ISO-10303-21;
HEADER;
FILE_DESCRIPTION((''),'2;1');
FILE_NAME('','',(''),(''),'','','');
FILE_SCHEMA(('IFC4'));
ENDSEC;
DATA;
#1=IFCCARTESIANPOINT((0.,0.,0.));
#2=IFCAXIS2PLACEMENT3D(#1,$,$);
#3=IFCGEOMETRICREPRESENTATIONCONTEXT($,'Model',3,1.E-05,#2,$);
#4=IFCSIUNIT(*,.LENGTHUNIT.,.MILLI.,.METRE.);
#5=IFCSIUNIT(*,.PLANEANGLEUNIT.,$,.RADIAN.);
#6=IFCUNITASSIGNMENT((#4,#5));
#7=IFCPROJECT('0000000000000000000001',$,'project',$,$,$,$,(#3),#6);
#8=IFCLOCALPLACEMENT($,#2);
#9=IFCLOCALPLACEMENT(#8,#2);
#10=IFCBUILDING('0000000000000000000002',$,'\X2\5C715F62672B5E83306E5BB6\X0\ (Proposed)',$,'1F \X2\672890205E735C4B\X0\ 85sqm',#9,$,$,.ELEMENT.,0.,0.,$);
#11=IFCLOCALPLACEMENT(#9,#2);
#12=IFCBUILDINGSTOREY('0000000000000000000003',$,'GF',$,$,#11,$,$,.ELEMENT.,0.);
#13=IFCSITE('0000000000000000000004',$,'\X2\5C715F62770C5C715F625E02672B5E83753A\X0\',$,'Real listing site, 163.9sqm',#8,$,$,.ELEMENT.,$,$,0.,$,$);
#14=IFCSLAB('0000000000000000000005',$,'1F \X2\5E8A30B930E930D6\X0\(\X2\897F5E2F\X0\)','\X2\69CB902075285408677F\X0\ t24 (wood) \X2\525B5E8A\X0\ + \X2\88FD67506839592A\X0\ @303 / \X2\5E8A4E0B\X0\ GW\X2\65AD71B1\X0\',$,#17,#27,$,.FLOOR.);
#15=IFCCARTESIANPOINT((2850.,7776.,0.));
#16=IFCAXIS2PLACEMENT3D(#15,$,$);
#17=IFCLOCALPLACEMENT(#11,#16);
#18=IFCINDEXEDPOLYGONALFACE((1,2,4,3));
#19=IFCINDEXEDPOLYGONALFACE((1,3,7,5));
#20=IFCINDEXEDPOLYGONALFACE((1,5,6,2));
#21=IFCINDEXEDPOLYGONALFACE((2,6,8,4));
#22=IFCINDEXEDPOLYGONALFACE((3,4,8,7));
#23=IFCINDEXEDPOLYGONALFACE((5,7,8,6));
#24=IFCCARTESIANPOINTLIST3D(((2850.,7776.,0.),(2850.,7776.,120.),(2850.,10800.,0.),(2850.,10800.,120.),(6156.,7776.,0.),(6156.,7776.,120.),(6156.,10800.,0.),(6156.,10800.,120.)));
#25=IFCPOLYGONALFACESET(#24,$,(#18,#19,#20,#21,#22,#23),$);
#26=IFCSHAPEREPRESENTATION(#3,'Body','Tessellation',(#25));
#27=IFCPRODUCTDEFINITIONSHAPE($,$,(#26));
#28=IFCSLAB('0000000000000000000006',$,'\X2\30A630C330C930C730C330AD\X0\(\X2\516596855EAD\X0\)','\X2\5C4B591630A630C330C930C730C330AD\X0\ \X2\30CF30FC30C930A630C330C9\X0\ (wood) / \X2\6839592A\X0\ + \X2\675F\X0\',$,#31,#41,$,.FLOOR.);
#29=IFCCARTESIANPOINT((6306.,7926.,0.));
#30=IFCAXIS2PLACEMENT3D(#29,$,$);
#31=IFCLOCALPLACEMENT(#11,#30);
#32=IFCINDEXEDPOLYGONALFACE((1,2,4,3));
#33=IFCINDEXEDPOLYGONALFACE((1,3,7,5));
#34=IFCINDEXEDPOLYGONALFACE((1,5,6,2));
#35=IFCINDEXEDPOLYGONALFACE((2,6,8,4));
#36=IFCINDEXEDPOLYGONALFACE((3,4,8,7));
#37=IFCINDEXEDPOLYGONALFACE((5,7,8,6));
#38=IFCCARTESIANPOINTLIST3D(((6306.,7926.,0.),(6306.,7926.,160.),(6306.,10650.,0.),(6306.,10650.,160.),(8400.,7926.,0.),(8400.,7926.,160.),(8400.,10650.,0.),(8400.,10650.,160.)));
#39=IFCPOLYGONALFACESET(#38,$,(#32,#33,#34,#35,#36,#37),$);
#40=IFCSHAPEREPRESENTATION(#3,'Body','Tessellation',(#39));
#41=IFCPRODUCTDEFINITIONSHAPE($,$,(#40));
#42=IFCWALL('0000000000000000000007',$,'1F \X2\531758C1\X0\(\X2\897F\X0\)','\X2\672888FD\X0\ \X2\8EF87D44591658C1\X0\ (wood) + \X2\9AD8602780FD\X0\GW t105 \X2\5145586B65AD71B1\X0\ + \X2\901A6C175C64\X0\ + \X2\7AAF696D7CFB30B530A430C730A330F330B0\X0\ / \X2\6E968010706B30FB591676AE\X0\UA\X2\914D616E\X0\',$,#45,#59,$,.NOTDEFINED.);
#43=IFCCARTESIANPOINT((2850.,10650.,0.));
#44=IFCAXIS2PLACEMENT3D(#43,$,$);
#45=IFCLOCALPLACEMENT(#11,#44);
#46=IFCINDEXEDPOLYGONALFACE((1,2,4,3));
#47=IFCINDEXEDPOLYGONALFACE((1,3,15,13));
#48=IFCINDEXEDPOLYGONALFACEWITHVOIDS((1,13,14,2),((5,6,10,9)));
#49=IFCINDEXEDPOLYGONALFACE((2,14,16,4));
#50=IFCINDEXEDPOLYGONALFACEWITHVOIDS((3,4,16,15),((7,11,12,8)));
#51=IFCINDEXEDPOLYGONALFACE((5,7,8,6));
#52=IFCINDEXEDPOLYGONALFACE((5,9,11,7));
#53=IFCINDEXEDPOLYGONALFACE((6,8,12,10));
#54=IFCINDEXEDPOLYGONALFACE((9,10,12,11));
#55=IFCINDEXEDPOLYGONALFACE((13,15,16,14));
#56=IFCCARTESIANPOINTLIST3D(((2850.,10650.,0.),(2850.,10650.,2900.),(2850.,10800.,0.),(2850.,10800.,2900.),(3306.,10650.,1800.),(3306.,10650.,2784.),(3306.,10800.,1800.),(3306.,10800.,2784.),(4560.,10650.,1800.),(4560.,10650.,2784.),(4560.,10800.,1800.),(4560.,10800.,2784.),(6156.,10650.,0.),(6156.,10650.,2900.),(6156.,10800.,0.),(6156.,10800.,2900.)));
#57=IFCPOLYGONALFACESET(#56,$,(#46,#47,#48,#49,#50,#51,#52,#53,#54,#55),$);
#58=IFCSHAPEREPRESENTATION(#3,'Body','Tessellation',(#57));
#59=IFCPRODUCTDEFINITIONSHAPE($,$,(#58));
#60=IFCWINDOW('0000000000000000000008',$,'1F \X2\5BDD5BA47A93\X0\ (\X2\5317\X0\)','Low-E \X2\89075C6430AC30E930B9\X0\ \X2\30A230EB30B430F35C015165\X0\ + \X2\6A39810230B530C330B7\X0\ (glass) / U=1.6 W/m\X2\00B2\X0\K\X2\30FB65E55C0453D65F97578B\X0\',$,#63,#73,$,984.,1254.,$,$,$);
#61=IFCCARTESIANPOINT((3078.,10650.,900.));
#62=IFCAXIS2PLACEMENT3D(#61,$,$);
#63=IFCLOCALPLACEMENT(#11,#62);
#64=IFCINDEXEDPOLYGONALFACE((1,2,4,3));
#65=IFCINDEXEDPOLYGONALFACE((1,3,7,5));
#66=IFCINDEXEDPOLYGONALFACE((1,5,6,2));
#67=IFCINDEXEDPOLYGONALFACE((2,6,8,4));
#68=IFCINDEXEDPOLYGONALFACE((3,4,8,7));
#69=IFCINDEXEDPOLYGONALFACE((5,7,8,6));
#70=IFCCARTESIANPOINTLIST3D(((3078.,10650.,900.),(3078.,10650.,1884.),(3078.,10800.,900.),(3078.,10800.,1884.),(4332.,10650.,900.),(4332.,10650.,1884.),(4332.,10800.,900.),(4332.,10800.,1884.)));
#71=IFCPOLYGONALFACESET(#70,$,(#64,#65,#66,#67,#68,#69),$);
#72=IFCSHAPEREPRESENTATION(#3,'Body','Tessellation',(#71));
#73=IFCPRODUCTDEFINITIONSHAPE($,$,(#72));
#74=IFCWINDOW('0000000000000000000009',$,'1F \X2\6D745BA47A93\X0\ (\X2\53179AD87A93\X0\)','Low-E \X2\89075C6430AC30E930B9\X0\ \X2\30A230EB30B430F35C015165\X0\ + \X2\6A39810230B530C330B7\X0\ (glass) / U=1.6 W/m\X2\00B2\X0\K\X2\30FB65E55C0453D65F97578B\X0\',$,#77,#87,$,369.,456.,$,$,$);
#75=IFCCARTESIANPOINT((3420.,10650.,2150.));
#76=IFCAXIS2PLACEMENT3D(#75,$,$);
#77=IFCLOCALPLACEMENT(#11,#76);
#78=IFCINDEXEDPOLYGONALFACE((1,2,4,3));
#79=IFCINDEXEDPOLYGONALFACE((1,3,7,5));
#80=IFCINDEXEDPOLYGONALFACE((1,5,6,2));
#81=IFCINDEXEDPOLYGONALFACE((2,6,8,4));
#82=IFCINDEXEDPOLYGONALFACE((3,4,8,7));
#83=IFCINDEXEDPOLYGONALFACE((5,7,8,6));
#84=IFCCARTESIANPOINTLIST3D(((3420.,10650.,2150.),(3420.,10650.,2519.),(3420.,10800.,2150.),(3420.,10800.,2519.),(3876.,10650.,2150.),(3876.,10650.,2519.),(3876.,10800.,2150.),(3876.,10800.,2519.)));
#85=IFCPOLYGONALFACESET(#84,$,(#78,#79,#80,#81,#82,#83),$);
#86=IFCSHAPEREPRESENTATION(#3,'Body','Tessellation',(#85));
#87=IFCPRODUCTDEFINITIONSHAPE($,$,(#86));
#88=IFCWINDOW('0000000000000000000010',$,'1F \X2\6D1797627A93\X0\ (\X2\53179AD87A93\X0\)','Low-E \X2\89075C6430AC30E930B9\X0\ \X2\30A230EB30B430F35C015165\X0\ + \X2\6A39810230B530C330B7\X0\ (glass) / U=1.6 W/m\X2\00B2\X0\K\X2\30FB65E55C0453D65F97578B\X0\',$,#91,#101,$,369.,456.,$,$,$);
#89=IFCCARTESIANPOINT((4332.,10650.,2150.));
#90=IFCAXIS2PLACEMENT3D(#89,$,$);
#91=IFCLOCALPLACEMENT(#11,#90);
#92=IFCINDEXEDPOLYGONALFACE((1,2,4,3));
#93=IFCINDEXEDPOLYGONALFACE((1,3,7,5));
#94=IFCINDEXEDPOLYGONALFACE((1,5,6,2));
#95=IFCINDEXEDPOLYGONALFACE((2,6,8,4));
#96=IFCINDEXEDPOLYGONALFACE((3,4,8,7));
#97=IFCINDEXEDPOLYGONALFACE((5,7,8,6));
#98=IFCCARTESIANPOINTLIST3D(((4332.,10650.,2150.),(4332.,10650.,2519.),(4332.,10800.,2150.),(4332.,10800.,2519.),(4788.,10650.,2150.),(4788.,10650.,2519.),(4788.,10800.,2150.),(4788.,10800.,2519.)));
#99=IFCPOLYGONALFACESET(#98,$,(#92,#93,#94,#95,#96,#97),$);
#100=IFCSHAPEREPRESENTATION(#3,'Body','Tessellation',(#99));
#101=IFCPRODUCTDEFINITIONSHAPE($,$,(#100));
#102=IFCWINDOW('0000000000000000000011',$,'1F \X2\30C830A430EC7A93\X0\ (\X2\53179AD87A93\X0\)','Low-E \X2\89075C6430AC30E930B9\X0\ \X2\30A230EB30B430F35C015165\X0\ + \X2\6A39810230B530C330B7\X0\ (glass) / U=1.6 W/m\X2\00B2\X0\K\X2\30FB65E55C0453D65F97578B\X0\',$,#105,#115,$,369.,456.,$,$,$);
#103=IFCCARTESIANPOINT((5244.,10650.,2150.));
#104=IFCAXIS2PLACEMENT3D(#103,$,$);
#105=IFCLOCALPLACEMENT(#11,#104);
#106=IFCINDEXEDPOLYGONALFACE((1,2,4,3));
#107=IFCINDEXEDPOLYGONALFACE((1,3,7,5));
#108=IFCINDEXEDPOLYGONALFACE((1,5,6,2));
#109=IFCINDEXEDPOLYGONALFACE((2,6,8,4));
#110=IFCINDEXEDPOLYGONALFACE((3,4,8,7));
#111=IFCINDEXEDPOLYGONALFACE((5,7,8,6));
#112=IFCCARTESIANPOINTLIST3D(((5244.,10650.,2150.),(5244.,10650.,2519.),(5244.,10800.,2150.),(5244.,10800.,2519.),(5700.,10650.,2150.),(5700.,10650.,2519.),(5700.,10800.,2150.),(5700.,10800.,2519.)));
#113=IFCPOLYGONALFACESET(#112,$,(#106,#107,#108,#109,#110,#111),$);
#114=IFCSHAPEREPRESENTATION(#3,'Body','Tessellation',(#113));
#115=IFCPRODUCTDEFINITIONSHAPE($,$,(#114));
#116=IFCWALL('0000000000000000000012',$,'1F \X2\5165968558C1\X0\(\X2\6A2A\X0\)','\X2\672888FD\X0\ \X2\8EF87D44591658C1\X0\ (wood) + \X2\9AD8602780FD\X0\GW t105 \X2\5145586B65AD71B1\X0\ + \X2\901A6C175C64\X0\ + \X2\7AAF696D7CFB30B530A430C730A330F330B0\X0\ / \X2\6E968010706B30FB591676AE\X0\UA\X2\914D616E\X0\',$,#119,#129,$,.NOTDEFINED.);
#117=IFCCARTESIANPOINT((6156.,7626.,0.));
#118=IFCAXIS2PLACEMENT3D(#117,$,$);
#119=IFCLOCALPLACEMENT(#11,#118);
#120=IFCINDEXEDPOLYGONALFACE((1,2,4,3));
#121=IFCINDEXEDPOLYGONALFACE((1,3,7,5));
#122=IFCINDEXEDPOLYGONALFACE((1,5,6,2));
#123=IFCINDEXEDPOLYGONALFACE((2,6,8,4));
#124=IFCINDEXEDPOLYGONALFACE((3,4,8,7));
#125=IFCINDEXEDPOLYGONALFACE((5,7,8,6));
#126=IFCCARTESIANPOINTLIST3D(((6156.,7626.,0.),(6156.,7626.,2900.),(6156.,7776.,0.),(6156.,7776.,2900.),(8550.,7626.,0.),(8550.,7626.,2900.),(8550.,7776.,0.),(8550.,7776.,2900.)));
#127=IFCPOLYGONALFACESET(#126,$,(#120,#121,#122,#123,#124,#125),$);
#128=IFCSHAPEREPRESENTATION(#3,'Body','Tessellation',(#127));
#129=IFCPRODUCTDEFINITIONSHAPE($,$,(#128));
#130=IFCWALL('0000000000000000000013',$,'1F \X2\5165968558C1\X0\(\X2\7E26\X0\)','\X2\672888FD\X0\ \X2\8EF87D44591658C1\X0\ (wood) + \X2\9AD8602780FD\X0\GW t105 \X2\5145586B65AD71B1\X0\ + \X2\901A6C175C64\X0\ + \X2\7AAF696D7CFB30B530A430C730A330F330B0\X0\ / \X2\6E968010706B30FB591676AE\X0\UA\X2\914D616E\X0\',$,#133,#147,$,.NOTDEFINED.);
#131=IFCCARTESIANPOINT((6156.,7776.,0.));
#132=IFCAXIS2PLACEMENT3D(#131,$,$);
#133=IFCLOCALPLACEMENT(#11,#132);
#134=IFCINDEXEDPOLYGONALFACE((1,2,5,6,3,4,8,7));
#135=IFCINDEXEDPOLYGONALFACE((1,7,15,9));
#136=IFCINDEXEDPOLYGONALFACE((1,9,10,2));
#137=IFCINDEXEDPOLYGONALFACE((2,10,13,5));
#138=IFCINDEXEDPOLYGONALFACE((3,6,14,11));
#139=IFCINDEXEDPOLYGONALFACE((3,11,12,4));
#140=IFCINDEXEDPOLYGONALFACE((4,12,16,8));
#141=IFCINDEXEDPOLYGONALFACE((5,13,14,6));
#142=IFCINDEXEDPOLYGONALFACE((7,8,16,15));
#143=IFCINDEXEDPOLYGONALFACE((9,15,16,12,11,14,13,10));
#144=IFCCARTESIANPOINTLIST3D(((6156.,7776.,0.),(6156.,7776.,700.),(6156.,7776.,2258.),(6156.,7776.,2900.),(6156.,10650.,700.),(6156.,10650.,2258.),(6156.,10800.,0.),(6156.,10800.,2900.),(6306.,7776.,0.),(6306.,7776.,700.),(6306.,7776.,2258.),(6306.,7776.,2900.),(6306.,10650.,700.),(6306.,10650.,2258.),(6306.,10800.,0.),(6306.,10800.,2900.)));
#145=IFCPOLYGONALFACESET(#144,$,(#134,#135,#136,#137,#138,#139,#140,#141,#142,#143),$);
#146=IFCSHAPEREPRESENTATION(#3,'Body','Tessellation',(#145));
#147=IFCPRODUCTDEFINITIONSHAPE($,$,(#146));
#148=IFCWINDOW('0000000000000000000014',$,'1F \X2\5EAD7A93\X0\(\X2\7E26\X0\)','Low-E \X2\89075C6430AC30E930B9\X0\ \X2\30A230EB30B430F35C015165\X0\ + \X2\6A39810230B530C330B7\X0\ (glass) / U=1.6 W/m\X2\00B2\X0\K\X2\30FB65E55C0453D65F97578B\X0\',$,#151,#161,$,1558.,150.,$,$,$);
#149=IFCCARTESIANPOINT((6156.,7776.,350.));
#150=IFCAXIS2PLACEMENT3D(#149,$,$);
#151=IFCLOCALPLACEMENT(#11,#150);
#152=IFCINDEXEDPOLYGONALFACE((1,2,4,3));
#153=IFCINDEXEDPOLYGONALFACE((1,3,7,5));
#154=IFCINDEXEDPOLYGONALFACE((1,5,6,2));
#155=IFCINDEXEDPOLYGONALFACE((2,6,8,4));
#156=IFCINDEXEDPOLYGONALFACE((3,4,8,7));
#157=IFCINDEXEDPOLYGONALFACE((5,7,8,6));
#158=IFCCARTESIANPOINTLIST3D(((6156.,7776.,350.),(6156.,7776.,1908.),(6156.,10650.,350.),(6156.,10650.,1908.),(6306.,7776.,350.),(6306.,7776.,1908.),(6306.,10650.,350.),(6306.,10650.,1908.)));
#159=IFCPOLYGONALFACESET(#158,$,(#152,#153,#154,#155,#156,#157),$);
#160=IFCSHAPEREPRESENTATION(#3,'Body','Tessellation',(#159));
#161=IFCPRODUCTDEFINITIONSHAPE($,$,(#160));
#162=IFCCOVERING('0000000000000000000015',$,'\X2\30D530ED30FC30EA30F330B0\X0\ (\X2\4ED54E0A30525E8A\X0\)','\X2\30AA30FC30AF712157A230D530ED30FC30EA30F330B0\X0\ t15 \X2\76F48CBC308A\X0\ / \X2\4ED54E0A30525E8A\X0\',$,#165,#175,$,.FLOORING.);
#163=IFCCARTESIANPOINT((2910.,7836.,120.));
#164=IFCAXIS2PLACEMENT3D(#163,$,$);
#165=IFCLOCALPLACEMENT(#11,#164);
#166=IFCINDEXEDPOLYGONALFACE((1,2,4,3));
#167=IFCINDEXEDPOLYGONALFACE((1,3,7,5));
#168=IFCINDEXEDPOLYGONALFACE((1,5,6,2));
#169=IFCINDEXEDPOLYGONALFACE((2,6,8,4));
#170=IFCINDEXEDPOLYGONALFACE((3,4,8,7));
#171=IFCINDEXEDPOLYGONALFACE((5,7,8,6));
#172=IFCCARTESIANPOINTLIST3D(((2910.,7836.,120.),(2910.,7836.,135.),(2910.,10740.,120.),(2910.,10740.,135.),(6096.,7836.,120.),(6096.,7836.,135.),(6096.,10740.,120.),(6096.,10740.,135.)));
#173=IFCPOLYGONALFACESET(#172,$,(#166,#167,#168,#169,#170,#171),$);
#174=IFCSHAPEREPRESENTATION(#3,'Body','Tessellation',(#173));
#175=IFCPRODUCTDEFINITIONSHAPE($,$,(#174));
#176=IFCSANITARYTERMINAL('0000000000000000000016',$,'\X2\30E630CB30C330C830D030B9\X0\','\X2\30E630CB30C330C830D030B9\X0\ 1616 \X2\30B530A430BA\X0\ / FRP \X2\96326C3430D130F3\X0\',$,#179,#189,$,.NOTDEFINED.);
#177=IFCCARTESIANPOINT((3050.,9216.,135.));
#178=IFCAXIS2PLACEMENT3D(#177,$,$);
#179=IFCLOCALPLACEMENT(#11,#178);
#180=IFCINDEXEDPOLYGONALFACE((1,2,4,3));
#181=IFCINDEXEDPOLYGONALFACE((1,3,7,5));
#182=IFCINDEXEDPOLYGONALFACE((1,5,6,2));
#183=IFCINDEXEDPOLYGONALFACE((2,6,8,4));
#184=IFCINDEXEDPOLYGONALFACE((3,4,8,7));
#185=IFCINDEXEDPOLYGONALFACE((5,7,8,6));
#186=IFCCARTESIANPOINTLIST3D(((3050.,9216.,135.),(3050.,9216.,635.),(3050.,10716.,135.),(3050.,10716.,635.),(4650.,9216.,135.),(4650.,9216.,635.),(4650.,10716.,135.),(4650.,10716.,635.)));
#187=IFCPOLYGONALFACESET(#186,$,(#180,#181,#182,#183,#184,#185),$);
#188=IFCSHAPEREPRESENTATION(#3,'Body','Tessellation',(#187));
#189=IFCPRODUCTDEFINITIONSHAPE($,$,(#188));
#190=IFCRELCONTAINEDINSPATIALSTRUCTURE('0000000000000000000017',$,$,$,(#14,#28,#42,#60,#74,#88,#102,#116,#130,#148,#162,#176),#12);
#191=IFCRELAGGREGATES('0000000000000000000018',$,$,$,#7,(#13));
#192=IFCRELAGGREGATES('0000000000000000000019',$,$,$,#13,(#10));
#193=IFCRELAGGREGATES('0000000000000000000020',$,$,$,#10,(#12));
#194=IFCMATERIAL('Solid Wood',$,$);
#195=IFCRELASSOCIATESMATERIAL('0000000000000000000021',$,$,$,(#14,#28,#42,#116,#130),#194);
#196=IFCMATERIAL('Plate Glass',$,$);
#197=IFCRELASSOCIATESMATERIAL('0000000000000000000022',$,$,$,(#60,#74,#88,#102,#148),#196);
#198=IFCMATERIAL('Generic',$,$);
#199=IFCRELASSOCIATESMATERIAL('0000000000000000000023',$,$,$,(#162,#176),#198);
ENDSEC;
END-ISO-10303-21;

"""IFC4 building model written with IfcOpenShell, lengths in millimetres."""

from ifc_helpers import new_model, si_unit, frame, frame_2d, origin, place, context, project, spatial, rectangle, extrude, material, element, fill, save


model = new_model("IFC4")

# Units and contexts
model_context = context("Model", 3, precision=1e-05, world=origin())
ifc_project = project(units=[si_unit("LENGTHUNIT", "METRE", prefix="MILLI"), si_unit("PLANEANGLEUNIT", "RADIAN")], contexts=[model_context])

# Site, building, storey
site_placement = place(None, origin())
site = spatial("IfcSite", under=ifc_project, at=site_placement, Name="山形県山形市末広町", ObjectType="Real listing site, 163.9sqm", CompositionType="ELEMENT", RefElevation=0.0)
building_placement = place(site_placement, origin())
building = spatial("IfcBuilding", under=site, at=building_placement, Name="山形末広の家 (Proposed)", ObjectType="1F 木造平屋 85sqm", CompositionType="ELEMENT", ElevationOfRefHeight=0.0, ElevationOfTerrain=0.0)
storey_placement = place(building_placement, origin())
storey = spatial("IfcBuildingStorey", under=building, at=storey_placement, Name="GF", CompositionType="ELEMENT", Elevation=0.0)

# Slabs
ifc_material_1 = material(Name="Solid Wood")
slab_1_placement = place(storey_placement, frame((2850.0, 7776.0, 0.0)))
element("IfcSlab", 1, at=slab_1_placement, inside=storey, material=ifc_material_1, Name="1F 床スラブ(西帯)", Description="構造用合板 t24 (wood) 剛床 + 製材根太 @303 / 床下 GW断熱", PredefinedType="FLOOR", context=model_context, shape_type="SweptSolid", body=[
    extrude(rectangle(XDim=3306.0, YDim=3024.0, at=frame_2d((1653.0, 1512.0))), frame((2850.0, 7776.0, 0.0)), (0.0, 0.0, 1.0), 120.0),
])
slab_2_placement = place(storey_placement, frame((6306.0, 7926.0, 0.0)))
element("IfcSlab", 2, at=slab_2_placement, inside=storey, material=ifc_material_1, Name="ウッドデッキ(入隅庭)", Description="屋外ウッドデッキ ハードウッド (wood) / 根太 + 束", PredefinedType="FLOOR", context=model_context, shape_type="SweptSolid", body=[
    extrude(rectangle(XDim=2094.0, YDim=2724.0, at=frame_2d((1047.0, 1362.0))), frame((6306.0, 7926.0, 0.0)), (0.0, 0.0, 1.0), 160.0),
])

# Wall, openings, windows
wall_1_placement = place(storey_placement, frame((2850.0, 10650.0, 0.0)))
wall_1 = element("IfcWall", 3, at=wall_1_placement, inside=storey, material=ifc_material_1, Name="1F 北壁(西)", Description="木製 軸組外壁 (wood) + 高性能GW t105 充填断熱 + 通気層 + 窯業系サイディング / 準耐火・外皮UA配慮", PredefinedType="NOTDEFINED", context=model_context, shape_type="SweptSolid", body=[
    extrude(rectangle(XDim=3306.0, YDim=150.0, at=frame_2d((1653.0, 75.0))), frame((2850.0, 10650.0, 0.0)), (0.0, 0.0, 1.0), 2900.0),
])
opening_1_placement = place(storey_placement, frame((3078.0, 10650.0, 900.0)))
opening_1 = element("IfcOpeningElement", 4, at=opening_1_placement, cuts=wall_1, PredefinedType="NOTDEFINED", context=model_context, shape_type="SweptSolid", body=[
    extrude(rectangle(XDim=1254.0, YDim=150.0, at=frame_2d((627.0, 75.0))), frame((3078.0, 10650.0, 900.0)), (0.0, 0.0, 1.0), 984.0),
])
opening_2_placement = place(storey_placement, frame((3420.0, 10650.0, 2150.0)))
opening_2 = element("IfcOpeningElement", 5, at=opening_2_placement, cuts=wall_1, PredefinedType="NOTDEFINED", context=model_context, shape_type="SweptSolid", body=[
    extrude(rectangle(XDim=456.0, YDim=150.0, at=frame_2d((228.0, 75.0))), frame((3420.0, 10650.0, 2150.0)), (0.0, 0.0, 1.0), 369.0),
])
opening_3_placement = place(storey_placement, frame((4332.0, 10650.0, 2150.0)))
opening_3 = element("IfcOpeningElement", 6, at=opening_3_placement, cuts=wall_1, PredefinedType="NOTDEFINED", context=model_context, shape_type="SweptSolid", body=[
    extrude(rectangle(XDim=456.0, YDim=150.0, at=frame_2d((228.0, 75.0))), frame((4332.0, 10650.0, 2150.0)), (0.0, 0.0, 1.0), 369.0),
])
opening_4_placement = place(storey_placement, frame((5244.0, 10650.0, 2150.0)))
opening_4 = element("IfcOpeningElement", 7, at=opening_4_placement, cuts=wall_1, PredefinedType="NOTDEFINED", context=model_context, shape_type="SweptSolid", body=[
    extrude(rectangle(XDim=456.0, YDim=150.0, at=frame_2d((228.0, 75.0))), frame((5244.0, 10650.0, 2150.0)), (0.0, 0.0, 1.0), 369.0),
])
ifc_material_2 = material(Name="Plate Glass")
window_1_placement = place(storey_placement, frame((3078.0, 10650.0, 900.0)))
window_1 = element("IfcWindow", 8, at=window_1_placement, inside=storey, material=ifc_material_2, Name="1F 寝室窓 (北)", Description="Low-E 複層ガラス アルゴン封入 + 樹脂サッシ (glass) / U=1.6 W/m²K・日射取得型", OverallHeight=984.0, OverallWidth=1254.0, context=model_context, shape_type="SweptSolid", body=[
    extrude(rectangle(XDim=1254.0, YDim=150.0, at=frame_2d((627.0, 75.0))), frame((3078.0, 10650.0, 900.0)), (0.0, 0.0, 1.0), 984.0),
])
fill(opening_1, window_1)
window_2_placement = place(storey_placement, frame((3420.0, 10650.0, 2150.0)))
window_2 = element("IfcWindow", 9, at=window_2_placement, inside=storey, material=ifc_material_2, Name="1F 浴室窓 (北高窓)", Description="Low-E 複層ガラス アルゴン封入 + 樹脂サッシ (glass) / U=1.6 W/m²K・日射取得型", OverallHeight=369.0, OverallWidth=456.0, context=model_context, shape_type="SweptSolid", body=[
    extrude(rectangle(XDim=456.0, YDim=150.0, at=frame_2d((228.0, 75.0))), frame((3420.0, 10650.0, 2150.0)), (0.0, 0.0, 1.0), 369.0),
])
fill(opening_2, window_2)
window_3_placement = place(storey_placement, frame((4332.0, 10650.0, 2150.0)))
window_3 = element("IfcWindow", 10, at=window_3_placement, inside=storey, material=ifc_material_2, Name="1F 洗面窓 (北高窓)", Description="Low-E 複層ガラス アルゴン封入 + 樹脂サッシ (glass) / U=1.6 W/m²K・日射取得型", OverallHeight=369.0, OverallWidth=456.0, context=model_context, shape_type="SweptSolid", body=[
    extrude(rectangle(XDim=456.0, YDim=150.0, at=frame_2d((228.0, 75.0))), frame((4332.0, 10650.0, 2150.0)), (0.0, 0.0, 1.0), 369.0),
])
fill(opening_3, window_3)
window_4_placement = place(storey_placement, frame((5244.0, 10650.0, 2150.0)))
window_4 = element("IfcWindow", 11, at=window_4_placement, inside=storey, material=ifc_material_2, Name="1F トイレ窓 (北高窓)", Description="Low-E 複層ガラス アルゴン封入 + 樹脂サッシ (glass) / U=1.6 W/m²K・日射取得型", OverallHeight=369.0, OverallWidth=456.0, context=model_context, shape_type="SweptSolid", body=[
    extrude(rectangle(XDim=456.0, YDim=150.0, at=frame_2d((228.0, 75.0))), frame((5244.0, 10650.0, 2150.0)), (0.0, 0.0, 1.0), 369.0),
])
fill(opening_4, window_4)

# Wall
wall_2_placement = place(storey_placement, frame((6156.0, 7626.0, 0.0)))
element("IfcWall", 12, at=wall_2_placement, inside=storey, material=ifc_material_1, Name="1F 入隅壁(横)", Description="木製 軸組外壁 (wood) + 高性能GW t105 充填断熱 + 通気層 + 窯業系サイディング / 準耐火・外皮UA配慮", PredefinedType="NOTDEFINED", context=model_context, shape_type="SweptSolid", body=[
    extrude(rectangle(XDim=2394.0, YDim=150.0, at=frame_2d((1197.0, 75.0))), frame((6156.0, 7626.0, 0.0)), (0.0, 0.0, 1.0), 2900.0),
])

# Wall, opening, window
wall_3_placement = place(storey_placement, frame((6156.0, 7776.0, 0.0)))
wall_3 = element("IfcWall", 13, at=wall_3_placement, inside=storey, material=ifc_material_1, Name="1F 入隅壁(縦)", Description="木製 軸組外壁 (wood) + 高性能GW t105 充填断熱 + 通気層 + 窯業系サイディング / 準耐火・外皮UA配慮", PredefinedType="NOTDEFINED", context=model_context, shape_type="SweptSolid", body=[
    extrude(rectangle(XDim=150.0, YDim=3024.0, at=frame_2d((75.0, 1512.0))), frame((6156.0, 7776.0, 0.0)), (0.0, 0.0, 1.0), 2900.0),
])
opening_5_placement = place(storey_placement, frame((6156.0, 7776.0, 350.0)))
opening_5 = element("IfcOpeningElement", 14, at=opening_5_placement, cuts=wall_3, PredefinedType="NOTDEFINED", context=model_context, shape_type="SweptSolid", body=[
    extrude(rectangle(XDim=150.0, YDim=2874.0, at=frame_2d((75.0, 1437.0))), frame((6156.0, 7776.0, 350.0)), (0.0, 0.0, 1.0), 1558.0),
])
window_5_placement = place(storey_placement, frame((6156.0, 7776.0, 350.0)))
window_5 = element("IfcWindow", 15, at=window_5_placement, inside=storey, material=ifc_material_2, Name="1F 庭窓(縦)", Description="Low-E 複層ガラス アルゴン封入 + 樹脂サッシ (glass) / U=1.6 W/m²K・日射取得型", OverallHeight=1558.0, OverallWidth=150.0, context=model_context, shape_type="SweptSolid", body=[
    extrude(rectangle(XDim=150.0, YDim=2874.0, at=frame_2d((75.0, 1437.0))), frame((6156.0, 7776.0, 350.0)), (0.0, 0.0, 1.0), 1558.0),
])
fill(opening_5, window_5)

# Covering
ifc_material_3 = material(Name="Generic")
covering_placement = place(storey_placement, frame((2910.0, 7836.0, 120.0)))
element("IfcCovering", 16, at=covering_placement, inside=storey, material=ifc_material_3, Name="フローリング (仕上げ床)", Description="オーク無垢フローリング t15 直貼り / 仕上げ床", PredefinedType="FLOORING", context=model_context, shape_type="SweptSolid", body=[
    extrude(rectangle(XDim=3186.0, YDim=2904.0, at=frame_2d((1593.0, 1452.0))), frame((2910.0, 7836.0, 120.0)), (0.0, 0.0, 1.0), 15.0),
])

# Sanitary terminal
sanitary_terminal_1_placement = place(storey_placement, frame((3050.0, 9216.0, 135.0)))
element("IfcSanitaryTerminal", 17, at=sanitary_terminal_1_placement, inside=storey, material=ifc_material_3, Name="ユニットバス", Description="ユニットバス 1616 サイズ / FRP 防水パン", PredefinedType="NOTDEFINED", context=model_context, shape_type="SweptSolid", body=[
    extrude(rectangle(XDim=1600.0, YDim=1500.0, at=frame_2d((800.0, 750.0))), frame((3050.0, 9216.0, 135.0)), (0.0, 0.0, 1.0), 500.0),
])

save(model, "model.ifc")
